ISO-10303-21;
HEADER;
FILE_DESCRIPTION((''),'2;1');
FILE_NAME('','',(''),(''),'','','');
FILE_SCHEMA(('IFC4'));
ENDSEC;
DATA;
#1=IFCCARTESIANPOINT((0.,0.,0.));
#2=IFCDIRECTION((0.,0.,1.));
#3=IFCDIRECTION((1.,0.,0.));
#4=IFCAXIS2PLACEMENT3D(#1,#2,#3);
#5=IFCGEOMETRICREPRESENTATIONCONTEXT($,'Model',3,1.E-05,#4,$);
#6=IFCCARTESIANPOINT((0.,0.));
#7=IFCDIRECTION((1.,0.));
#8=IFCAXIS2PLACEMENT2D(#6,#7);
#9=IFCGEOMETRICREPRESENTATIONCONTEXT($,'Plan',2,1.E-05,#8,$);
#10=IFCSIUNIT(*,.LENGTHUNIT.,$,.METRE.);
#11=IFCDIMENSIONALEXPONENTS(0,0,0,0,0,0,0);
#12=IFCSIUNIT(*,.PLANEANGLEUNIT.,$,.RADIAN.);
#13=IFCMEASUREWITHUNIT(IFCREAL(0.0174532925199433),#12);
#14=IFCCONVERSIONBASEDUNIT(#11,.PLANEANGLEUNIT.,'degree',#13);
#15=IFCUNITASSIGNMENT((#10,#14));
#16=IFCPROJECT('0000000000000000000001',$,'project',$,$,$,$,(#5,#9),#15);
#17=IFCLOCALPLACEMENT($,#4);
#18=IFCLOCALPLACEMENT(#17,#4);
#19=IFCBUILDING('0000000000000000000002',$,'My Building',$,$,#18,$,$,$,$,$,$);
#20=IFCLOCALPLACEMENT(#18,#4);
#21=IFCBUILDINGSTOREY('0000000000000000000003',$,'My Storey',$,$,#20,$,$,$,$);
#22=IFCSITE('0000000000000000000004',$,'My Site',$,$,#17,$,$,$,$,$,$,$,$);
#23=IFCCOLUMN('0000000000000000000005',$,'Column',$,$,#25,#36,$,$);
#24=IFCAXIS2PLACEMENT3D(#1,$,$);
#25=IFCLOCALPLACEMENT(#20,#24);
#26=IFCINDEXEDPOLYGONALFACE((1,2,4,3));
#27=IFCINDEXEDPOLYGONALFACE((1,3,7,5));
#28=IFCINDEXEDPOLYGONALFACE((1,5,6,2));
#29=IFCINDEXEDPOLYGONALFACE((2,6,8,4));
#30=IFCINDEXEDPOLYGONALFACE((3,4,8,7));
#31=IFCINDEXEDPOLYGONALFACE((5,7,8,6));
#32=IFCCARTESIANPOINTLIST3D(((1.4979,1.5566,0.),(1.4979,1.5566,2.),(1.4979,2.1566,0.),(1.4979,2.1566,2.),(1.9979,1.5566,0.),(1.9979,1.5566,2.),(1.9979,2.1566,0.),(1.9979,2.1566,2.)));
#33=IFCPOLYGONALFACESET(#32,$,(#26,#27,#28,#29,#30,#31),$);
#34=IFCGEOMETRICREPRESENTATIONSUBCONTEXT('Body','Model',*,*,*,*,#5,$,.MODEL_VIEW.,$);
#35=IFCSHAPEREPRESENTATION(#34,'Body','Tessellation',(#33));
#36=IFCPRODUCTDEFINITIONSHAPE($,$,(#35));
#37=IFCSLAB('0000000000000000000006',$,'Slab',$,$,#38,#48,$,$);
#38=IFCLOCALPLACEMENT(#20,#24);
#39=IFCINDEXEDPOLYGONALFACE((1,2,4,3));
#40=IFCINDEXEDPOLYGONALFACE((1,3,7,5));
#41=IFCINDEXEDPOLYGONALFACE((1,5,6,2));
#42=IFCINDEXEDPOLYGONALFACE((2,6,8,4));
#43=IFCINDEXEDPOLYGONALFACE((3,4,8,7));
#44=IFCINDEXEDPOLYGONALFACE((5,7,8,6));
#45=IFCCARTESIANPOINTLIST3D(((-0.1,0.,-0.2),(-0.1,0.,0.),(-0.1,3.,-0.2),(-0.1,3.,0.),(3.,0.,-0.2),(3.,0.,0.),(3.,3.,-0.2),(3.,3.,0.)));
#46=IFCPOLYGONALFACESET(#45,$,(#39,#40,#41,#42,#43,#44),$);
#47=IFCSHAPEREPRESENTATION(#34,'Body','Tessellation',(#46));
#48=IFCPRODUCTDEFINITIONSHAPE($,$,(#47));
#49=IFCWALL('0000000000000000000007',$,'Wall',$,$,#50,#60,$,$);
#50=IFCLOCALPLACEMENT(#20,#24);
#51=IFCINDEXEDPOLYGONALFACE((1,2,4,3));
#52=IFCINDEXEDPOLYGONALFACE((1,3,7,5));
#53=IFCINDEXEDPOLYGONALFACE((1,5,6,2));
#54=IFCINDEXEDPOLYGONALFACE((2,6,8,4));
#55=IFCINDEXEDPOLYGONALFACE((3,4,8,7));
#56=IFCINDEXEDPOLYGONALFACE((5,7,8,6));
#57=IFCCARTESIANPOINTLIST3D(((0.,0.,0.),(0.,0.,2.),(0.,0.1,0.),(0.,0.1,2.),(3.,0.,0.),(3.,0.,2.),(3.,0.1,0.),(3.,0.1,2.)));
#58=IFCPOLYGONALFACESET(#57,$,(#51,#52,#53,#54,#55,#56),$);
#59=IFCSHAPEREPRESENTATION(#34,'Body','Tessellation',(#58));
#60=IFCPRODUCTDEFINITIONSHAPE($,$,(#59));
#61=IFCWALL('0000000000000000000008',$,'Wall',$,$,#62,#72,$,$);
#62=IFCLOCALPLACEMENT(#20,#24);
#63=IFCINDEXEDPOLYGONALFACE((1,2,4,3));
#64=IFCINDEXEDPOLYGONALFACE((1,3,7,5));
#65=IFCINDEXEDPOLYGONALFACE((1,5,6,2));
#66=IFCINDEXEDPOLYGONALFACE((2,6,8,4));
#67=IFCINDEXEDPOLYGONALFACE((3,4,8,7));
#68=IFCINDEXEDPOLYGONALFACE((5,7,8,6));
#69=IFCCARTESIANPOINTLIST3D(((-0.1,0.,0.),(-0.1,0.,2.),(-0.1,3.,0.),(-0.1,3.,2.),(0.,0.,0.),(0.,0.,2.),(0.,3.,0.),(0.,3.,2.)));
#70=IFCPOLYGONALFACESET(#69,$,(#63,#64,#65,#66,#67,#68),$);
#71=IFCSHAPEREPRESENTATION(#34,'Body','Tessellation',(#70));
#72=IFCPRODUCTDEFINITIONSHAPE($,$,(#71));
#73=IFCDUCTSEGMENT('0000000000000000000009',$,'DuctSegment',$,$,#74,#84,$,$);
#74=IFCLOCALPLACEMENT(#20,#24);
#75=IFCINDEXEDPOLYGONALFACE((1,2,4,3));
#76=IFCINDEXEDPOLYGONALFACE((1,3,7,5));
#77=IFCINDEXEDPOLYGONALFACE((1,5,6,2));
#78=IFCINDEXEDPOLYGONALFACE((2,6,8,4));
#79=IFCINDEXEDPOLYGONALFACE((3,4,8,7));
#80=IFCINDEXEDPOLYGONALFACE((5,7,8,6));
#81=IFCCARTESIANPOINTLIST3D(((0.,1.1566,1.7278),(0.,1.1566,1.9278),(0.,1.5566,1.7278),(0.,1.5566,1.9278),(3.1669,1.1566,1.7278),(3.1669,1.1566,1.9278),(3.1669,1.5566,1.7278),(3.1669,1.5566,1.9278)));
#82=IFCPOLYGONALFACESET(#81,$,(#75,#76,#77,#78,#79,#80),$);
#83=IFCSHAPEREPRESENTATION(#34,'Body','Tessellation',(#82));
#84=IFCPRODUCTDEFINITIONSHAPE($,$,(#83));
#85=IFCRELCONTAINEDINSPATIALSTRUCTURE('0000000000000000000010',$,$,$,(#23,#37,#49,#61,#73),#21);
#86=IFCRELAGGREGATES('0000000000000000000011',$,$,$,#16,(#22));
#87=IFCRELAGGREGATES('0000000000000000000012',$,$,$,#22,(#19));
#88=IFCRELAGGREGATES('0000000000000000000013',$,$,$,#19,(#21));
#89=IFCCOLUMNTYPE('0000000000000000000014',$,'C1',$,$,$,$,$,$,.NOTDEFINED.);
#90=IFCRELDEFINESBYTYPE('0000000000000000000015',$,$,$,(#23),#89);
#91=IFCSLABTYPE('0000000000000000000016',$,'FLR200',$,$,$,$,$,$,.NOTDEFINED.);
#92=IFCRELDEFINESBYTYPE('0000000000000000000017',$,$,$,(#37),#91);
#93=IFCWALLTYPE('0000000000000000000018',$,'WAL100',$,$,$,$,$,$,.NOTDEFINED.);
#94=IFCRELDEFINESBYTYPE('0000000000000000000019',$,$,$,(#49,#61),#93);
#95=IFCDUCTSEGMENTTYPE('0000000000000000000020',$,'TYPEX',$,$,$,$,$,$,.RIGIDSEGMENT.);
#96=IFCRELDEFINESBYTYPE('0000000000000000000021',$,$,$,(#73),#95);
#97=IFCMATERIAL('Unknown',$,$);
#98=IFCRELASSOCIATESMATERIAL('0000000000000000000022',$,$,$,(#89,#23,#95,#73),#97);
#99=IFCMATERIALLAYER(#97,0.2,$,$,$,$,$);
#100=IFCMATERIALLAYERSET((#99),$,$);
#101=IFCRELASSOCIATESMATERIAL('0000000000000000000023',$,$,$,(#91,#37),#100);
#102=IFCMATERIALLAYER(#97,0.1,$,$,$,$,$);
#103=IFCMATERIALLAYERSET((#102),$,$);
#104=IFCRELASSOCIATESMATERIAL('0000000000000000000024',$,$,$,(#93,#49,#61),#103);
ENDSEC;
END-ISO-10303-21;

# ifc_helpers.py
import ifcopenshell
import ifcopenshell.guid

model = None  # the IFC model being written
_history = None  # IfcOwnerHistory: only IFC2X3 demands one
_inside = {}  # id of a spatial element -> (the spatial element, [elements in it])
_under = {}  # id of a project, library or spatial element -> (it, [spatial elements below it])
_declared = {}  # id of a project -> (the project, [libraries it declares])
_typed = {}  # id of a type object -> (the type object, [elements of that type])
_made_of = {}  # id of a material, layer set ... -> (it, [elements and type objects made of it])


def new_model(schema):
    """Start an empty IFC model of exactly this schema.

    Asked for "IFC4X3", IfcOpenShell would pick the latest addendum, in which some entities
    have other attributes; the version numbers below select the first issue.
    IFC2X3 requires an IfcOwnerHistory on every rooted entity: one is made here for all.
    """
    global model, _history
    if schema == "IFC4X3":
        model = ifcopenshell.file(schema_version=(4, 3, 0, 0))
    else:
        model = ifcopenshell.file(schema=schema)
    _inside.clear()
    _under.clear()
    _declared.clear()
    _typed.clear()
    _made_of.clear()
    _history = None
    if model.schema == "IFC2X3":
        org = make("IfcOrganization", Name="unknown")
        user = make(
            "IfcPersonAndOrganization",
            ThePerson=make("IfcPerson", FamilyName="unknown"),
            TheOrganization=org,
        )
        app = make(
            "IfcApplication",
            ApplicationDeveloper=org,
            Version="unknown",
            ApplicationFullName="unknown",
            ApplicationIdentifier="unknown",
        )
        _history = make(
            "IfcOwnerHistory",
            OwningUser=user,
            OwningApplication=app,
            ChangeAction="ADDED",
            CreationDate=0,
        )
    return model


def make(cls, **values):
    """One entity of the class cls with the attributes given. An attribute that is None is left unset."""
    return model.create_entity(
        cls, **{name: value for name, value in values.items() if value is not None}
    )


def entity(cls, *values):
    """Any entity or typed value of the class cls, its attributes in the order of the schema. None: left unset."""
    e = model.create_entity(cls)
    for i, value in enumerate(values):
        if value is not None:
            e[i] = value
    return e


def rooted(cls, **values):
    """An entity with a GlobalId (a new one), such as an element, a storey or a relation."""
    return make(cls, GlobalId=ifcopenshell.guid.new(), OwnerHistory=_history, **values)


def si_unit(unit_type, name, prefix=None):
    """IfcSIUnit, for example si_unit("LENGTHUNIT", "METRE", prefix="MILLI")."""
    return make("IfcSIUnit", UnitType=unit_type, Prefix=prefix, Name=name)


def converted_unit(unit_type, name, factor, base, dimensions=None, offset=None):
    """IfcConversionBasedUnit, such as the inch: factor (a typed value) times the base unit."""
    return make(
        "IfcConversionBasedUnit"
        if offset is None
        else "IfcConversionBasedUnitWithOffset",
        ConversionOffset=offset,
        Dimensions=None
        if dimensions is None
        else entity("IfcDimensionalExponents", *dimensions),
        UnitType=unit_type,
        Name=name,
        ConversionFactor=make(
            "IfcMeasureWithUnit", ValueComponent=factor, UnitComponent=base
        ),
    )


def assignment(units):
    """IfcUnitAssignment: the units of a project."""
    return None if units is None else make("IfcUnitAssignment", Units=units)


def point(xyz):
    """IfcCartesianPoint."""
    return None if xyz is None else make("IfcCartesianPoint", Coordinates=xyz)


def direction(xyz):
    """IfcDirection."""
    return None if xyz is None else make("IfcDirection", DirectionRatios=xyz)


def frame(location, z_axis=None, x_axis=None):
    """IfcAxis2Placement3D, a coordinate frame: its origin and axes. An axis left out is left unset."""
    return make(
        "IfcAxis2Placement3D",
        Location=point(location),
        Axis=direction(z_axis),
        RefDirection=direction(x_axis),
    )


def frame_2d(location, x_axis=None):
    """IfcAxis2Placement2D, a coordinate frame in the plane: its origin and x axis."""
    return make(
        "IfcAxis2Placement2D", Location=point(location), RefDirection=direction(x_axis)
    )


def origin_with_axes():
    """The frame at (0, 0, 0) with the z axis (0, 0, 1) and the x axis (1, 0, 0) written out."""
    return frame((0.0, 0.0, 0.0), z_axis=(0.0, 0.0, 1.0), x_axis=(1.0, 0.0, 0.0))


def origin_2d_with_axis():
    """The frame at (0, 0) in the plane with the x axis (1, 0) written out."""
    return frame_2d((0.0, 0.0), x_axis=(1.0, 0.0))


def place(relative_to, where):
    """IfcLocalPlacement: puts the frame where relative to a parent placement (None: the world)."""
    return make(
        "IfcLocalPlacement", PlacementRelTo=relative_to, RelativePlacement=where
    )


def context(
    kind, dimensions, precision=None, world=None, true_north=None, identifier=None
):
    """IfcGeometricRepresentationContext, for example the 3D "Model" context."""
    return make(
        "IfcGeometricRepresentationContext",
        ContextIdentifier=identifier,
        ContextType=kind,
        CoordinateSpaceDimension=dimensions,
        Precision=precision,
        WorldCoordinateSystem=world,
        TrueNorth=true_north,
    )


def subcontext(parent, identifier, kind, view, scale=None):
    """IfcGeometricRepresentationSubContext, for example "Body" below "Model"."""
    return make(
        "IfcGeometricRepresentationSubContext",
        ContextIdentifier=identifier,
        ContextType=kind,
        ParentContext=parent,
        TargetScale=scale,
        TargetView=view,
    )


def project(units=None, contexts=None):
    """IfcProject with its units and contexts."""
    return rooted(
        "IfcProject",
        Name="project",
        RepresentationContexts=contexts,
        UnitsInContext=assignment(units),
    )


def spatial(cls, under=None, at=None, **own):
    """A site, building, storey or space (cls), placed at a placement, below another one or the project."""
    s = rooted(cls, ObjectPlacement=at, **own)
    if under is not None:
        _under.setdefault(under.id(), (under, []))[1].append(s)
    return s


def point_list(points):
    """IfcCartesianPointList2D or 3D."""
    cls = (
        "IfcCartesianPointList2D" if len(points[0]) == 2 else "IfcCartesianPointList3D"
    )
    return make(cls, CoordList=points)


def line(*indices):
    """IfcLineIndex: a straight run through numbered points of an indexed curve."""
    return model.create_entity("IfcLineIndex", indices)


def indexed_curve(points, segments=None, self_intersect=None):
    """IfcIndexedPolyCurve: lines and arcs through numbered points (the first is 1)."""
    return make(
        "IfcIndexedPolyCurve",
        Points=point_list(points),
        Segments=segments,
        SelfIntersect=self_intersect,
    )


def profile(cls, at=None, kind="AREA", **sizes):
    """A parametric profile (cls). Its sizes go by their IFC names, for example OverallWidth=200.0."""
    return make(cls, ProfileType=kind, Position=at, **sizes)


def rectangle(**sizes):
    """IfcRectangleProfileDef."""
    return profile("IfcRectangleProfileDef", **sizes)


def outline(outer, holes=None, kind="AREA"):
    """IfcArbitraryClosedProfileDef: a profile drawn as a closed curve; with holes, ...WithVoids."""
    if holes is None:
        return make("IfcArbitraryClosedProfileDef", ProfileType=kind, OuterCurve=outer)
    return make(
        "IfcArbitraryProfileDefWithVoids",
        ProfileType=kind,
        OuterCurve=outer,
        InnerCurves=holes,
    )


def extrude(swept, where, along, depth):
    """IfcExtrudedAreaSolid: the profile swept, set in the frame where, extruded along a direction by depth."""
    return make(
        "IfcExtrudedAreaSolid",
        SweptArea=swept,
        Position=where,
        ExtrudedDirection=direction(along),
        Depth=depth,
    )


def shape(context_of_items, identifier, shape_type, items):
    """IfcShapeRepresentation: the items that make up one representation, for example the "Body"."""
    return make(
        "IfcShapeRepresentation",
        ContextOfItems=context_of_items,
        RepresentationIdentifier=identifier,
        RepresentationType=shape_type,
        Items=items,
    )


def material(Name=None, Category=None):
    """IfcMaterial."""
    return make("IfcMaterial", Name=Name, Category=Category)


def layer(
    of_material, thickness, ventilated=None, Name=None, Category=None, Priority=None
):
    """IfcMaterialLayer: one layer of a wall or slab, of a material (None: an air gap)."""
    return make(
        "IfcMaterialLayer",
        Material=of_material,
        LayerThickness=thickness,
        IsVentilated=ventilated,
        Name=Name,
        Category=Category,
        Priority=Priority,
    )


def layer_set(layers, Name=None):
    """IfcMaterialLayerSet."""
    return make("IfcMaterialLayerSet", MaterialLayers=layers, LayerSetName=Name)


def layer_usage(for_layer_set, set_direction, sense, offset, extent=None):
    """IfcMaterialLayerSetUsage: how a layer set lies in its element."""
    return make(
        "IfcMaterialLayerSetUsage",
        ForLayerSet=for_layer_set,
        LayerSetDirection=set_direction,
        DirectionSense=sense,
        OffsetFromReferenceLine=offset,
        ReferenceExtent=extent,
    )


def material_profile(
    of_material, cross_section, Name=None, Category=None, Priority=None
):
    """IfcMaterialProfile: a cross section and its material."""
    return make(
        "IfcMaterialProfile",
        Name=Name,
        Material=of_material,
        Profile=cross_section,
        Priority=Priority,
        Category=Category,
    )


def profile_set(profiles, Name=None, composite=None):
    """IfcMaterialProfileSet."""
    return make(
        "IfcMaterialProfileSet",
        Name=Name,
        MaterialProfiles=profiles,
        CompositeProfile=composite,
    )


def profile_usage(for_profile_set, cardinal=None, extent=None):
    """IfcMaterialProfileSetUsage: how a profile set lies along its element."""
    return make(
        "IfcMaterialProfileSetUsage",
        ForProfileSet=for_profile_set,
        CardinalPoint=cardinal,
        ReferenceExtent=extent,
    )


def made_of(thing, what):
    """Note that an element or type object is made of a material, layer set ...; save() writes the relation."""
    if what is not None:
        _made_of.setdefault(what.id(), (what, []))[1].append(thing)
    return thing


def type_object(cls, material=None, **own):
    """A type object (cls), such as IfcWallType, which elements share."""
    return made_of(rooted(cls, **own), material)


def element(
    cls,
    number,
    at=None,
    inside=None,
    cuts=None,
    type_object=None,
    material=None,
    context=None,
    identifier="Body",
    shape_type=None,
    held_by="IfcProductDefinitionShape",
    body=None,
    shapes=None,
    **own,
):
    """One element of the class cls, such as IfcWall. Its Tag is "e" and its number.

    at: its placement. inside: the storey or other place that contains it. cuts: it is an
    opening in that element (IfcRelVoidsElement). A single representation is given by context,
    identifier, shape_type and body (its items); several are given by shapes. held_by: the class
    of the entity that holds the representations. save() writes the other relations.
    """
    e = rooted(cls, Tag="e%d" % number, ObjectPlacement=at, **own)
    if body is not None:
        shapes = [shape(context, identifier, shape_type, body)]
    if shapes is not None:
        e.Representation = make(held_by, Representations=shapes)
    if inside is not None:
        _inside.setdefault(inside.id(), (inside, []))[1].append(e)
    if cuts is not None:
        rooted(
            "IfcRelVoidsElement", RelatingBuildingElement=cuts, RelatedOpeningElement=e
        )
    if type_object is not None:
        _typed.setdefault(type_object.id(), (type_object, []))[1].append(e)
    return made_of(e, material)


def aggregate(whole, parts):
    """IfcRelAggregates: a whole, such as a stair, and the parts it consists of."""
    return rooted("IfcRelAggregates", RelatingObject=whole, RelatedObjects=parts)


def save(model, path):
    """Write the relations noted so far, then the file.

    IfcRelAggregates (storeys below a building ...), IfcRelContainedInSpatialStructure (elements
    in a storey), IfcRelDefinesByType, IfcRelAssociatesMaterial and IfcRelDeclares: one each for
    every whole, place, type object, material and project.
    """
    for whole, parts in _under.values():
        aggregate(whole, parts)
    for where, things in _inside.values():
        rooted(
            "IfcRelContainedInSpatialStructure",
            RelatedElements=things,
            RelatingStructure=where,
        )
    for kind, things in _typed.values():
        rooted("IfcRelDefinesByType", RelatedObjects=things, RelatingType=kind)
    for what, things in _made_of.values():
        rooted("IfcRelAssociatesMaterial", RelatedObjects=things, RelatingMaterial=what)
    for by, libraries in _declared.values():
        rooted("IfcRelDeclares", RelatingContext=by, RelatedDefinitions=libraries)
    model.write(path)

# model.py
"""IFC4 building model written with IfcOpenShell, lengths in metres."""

from ifc_helpers import new_model, entity, si_unit, converted_unit, frame, origin_with_axes, origin_2d_with_axis, place, context, subcontext, project, spatial, line, indexed_curve, rectangle, outline, extrude, material, layer, layer_set, layer_usage, material_profile, profile_set, profile_usage, type_object, element, save


model = new_model("IFC4")

# Units and contexts
model_context = context("Model", 3, precision=1e-05, world=origin_with_axes())
plan_context = context("Plan", 2, precision=1e-05, world=origin_2d_with_axis())
body_context = subcontext(model_context, "Body", "Model", "MODEL_VIEW")
ifc_project = project(units=[si_unit("LENGTHUNIT", "METRE"), converted_unit("PLANEANGLEUNIT", "degree", entity("IfcReal", 0.0174532925199433), si_unit("PLANEANGLEUNIT", "RADIAN"), dimensions=[0, 0, 0, 0, 0, 0, 0])], contexts=[model_context, plan_context])

# Site, building, storey
site_placement = place(None, origin_with_axes())
site = spatial("IfcSite", under=ifc_project, at=site_placement, Name="My Site")
building_placement = place(site_placement, origin_with_axes())
building = spatial("IfcBuilding", under=site, at=building_placement, Name="My Building")
storey_placement = place(building_placement, origin_with_axes())
storey = spatial("IfcBuildingStorey", under=building, at=storey_placement, Name="My Storey")

# Column
ifc_material = material(Name="Unknown")
ifc_material_profile_1 = material_profile(ifc_material, rectangle(XDim=0.5, YDim=0.6))
ifc_profile_set_1 = profile_set([ifc_material_profile_1])
ifc_profile_usage_1 = profile_usage(ifc_profile_set_1, cardinal=5)
column_type = type_object("IfcColumnType", Name="C1", PredefinedType="NOTDEFINED", material=ifc_profile_set_1)
column_placement = place(storey_placement, frame((1.7479, 1.8566, 0.0), z_axis=(0.0, 0.0, 1.0), x_axis=(1.0, 0.0, 0.0)))
element("IfcColumn", 1, at=column_placement, inside=storey, type_object=column_type, material=ifc_profile_usage_1, Name="Column", context=body_context, shape_type="SweptSolid", body=[
    extrude(rectangle(XDim=0.5, YDim=0.6), origin_with_axes(), (0.0, 0.0, 1.0), 2.0),
])

# Slab
ifc_layer_1 = layer(ifc_material, 0.2)
ifc_layer_set_1 = layer_set([ifc_layer_1])
ifc_layer_usage_1 = layer_usage(ifc_layer_set_1, "AXIS3", "POSITIVE", 0.0)
slab_type = type_object("IfcSlabType", Name="FLR200", PredefinedType="NOTDEFINED", material=ifc_layer_set_1)
slab_placement = place(storey_placement, frame((0.0, 0.0, -0.2), z_axis=(0.0, 0.0, 1.0), x_axis=(1.0, 0.0, 0.0)))
element("IfcSlab", 2, at=slab_placement, inside=storey, type_object=slab_type, material=ifc_layer_usage_1, Name="Slab", context=body_context, shape_type="SweptSolid", body=[
    extrude(outline(indexed_curve([(-0.1, 3.0), (-0.1, 0.0), (3.0, 0.0), (3.0, 3.0)], segments=[line(4, 1), line(1, 2), line(2, 3), line(3, 4)], self_intersect=False)), None, (0.0, 0.0, 1.0), 0.2),
])

# Walls
ifc_layer_2 = layer(ifc_material, 0.1)
ifc_layer_set_2 = layer_set([ifc_layer_2])
ifc_layer_usage_2 = layer_usage(ifc_layer_set_2, "AXIS2", "POSITIVE", 0.0)
wall_type = type_object("IfcWallType", Name="WAL100", PredefinedType="NOTDEFINED", material=ifc_layer_set_2)
wall_1_placement = place(storey_placement, frame((0.0, 0.0, 0.0), z_axis=(0.0, 0.0, 1.0), x_axis=(1.0, -0.000001, 0.0)))
element("IfcWall", 3, at=wall_1_placement, inside=storey, type_object=wall_type, material=ifc_layer_usage_2, Name="Wall", context=body_context, shape_type="SweptSolid", body=[
    extrude(outline(indexed_curve([(0.0, 0.0), (0.0, 0.1), (3.0, 0.1), (3.0, 0.0), (0.0, 0.0)], self_intersect=False)), origin_with_axes(), (0.0, 0.0, 1.0), 2.0),
])
ifc_layer_usage_3 = layer_usage(ifc_layer_set_2, "AXIS2", "POSITIVE", 0.0)
wall_2_placement = place(storey_placement, frame((0.0, 0.0, 0.0), z_axis=(0.0, 0.0, 1.0), x_axis=(0.000001, 1.0, 0.0)))
element("IfcWall", 4, at=wall_2_placement, inside=storey, type_object=wall_type, material=ifc_layer_usage_3, Name="Wall", context=body_context, shape_type="SweptSolid", body=[
    extrude(outline(indexed_curve([(0.0, 0.0), (0.0, 0.1), (3.0, 0.1), (3.0, 0.0), (0.0, 0.0)], self_intersect=False)), origin_with_axes(), (0.0, 0.0, 1.0), 2.0),
])

# Duct segment
ifc_material_profile_2 = material_profile(ifc_material, rectangle(XDim=0.4, YDim=0.2))
ifc_profile_set_2 = profile_set([ifc_material_profile_2])
ifc_profile_usage_2 = profile_usage(ifc_profile_set_2, cardinal=5)
duct_segment_type = type_object("IfcDuctSegmentType", Name="TYPEX", PredefinedType="RIGIDSEGMENT", material=ifc_profile_set_2)
duct_segment_placement = place(storey_placement, frame((0.0, 1.3566, 1.8278), z_axis=(1.0, 0.0, 0.0), x_axis=(0.0, 1.0, 0.0)))
element("IfcDuctSegment", 5, at=duct_segment_placement, inside=storey, type_object=duct_segment_type, material=ifc_profile_usage_2, Name="DuctSegment", context=body_context, shape_type="SweptSolid", body=[
    extrude(rectangle(XDim=0.4, YDim=0.2), origin_with_axes(), (0.0, 0.0, 1.0), 3.1669),
])

save(model, "model.ifc")
